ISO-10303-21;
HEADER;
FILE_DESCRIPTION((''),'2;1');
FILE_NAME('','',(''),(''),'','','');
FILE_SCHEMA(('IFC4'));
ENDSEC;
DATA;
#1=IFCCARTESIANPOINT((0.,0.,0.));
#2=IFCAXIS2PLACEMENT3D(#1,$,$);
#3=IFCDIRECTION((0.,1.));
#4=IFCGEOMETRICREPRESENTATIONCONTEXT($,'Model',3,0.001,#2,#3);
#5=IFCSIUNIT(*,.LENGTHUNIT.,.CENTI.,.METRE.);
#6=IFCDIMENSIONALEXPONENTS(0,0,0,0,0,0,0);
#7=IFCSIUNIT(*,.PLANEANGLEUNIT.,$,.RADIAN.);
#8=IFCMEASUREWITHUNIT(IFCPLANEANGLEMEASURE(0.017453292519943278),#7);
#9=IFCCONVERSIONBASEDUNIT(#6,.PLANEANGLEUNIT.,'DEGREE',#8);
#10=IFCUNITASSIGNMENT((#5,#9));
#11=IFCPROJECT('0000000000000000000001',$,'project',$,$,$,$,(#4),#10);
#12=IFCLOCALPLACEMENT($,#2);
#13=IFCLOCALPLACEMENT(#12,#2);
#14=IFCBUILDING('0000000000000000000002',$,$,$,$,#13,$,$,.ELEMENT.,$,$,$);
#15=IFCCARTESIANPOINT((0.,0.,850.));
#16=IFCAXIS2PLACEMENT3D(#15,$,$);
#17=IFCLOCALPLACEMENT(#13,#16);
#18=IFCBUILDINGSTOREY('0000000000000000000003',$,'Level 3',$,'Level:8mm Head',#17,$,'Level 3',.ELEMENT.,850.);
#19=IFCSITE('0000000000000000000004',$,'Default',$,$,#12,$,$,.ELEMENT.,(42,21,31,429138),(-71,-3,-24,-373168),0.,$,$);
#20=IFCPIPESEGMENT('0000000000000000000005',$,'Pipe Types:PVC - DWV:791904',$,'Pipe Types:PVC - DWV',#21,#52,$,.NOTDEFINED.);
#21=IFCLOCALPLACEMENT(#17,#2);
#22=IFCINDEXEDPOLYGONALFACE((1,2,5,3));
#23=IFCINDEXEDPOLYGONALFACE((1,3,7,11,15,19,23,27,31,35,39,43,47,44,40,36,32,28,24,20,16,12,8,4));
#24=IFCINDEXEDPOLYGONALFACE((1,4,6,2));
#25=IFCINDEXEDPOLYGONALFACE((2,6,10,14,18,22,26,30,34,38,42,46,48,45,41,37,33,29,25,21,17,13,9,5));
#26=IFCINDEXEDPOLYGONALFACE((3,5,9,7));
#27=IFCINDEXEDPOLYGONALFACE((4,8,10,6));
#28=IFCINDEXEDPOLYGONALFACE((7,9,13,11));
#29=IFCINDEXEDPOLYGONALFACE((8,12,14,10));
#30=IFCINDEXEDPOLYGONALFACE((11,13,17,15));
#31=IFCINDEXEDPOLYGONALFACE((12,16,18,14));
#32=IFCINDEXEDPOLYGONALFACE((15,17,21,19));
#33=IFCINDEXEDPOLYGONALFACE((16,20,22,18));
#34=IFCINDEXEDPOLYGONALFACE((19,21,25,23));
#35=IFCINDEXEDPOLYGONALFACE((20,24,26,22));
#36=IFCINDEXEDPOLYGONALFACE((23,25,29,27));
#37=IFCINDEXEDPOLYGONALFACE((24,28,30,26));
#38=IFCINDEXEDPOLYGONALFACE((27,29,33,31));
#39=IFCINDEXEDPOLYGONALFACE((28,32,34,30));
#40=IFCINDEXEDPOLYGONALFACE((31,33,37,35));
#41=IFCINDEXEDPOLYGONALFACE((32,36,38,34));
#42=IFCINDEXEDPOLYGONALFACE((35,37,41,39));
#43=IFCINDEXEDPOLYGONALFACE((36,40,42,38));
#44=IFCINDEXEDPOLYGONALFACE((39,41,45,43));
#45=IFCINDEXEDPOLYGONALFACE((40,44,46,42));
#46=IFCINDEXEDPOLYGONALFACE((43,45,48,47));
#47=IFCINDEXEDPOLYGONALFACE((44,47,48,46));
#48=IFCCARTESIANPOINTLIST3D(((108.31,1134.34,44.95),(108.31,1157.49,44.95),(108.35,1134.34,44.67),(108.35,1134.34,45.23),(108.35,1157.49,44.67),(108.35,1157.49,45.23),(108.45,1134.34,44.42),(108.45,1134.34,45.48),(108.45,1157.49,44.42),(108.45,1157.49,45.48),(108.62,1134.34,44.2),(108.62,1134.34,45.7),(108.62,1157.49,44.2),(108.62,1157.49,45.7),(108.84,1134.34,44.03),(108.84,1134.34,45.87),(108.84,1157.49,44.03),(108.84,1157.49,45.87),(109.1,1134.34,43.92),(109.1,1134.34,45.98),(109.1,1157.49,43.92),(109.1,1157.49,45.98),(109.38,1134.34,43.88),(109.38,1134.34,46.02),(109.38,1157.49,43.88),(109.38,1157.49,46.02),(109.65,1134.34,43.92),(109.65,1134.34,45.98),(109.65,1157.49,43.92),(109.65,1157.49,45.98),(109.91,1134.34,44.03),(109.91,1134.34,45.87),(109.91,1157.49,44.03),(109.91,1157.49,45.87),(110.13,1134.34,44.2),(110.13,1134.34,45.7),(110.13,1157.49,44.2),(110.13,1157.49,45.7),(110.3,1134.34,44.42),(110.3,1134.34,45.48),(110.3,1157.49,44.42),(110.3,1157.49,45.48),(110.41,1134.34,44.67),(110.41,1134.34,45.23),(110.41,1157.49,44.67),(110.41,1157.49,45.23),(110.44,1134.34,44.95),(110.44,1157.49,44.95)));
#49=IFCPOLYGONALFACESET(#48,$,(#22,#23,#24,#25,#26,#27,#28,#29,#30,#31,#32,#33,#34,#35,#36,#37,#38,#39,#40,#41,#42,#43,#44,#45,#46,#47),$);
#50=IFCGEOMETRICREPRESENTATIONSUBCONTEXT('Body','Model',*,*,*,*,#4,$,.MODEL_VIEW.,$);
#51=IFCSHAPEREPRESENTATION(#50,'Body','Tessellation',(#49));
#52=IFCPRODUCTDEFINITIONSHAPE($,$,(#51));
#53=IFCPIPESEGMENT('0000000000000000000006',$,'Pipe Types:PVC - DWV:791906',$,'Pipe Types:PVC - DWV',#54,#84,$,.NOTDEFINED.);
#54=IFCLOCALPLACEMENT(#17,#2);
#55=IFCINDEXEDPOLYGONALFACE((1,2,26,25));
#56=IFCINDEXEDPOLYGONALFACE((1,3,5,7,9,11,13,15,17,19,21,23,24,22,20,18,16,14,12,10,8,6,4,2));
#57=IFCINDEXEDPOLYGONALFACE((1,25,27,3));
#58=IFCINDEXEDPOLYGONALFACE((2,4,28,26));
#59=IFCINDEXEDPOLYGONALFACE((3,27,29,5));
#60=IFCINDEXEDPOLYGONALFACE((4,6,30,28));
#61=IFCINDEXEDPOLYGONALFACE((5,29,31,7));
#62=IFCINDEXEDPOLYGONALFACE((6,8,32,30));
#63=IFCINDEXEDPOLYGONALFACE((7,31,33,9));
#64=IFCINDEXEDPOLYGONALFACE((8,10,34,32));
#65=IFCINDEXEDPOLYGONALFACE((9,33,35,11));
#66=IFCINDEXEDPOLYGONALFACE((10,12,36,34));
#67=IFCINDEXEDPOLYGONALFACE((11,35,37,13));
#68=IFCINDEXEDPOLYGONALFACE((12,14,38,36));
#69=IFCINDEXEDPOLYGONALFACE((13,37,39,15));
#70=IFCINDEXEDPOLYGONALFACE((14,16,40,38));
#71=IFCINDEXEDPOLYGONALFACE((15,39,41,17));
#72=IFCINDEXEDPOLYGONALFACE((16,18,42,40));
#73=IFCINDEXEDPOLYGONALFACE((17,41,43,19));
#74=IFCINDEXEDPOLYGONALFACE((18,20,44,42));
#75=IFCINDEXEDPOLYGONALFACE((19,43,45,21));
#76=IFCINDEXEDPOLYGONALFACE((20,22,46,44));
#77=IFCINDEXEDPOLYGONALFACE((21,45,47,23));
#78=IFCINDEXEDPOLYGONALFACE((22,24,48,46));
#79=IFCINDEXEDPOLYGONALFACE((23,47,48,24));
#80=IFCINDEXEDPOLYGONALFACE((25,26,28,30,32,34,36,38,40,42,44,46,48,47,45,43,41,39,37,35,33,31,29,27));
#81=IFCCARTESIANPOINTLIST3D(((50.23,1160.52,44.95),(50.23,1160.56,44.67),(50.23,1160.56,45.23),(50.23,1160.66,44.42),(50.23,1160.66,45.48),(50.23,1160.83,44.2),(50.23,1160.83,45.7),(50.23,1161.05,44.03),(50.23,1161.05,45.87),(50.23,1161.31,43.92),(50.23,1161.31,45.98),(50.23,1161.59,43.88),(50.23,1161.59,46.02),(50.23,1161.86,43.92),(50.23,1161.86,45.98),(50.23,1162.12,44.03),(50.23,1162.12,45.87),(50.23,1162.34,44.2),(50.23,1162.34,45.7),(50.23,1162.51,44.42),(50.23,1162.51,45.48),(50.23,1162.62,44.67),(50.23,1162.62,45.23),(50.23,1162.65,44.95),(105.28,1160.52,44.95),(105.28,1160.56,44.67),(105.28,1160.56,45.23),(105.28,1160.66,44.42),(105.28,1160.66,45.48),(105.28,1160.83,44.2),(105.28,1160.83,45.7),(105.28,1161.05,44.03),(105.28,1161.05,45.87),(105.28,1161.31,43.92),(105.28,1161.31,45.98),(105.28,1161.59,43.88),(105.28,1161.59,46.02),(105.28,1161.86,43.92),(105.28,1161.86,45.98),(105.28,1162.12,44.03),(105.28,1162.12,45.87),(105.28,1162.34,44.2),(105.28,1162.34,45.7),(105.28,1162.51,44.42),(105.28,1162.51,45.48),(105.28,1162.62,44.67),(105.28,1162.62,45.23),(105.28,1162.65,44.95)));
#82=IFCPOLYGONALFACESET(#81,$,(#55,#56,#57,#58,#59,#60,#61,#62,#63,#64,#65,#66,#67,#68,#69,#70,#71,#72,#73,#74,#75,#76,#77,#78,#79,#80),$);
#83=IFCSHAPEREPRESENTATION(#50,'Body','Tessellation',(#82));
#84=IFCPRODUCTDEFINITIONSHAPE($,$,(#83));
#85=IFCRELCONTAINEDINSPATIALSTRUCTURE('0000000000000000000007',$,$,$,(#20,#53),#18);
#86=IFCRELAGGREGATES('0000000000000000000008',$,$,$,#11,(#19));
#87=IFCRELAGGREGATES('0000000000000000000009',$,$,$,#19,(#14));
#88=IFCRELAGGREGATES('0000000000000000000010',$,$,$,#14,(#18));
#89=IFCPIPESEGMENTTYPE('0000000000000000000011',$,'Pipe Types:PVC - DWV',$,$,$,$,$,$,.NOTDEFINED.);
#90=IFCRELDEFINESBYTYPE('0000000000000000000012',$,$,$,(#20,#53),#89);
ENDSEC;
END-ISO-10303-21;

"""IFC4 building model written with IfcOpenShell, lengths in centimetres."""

from ifc_helpers import new_model, entity, si_unit, converted_unit, direction, frame, origin, place, context, subcontext, project, spatial, arc, indexed_curve, outline, extrude, type_object, element, save


model = new_model("IFC4")

# Units and contexts
model_context = context("Model", 3, precision=0.001, world=origin(), true_north=direction((0.0, 1.0)))
body_context = subcontext(model_context, "Body", "Model", "MODEL_VIEW")
ifc_project = project(units=[si_unit("LENGTHUNIT", "METRE", prefix="CENTI"), converted_unit("PLANEANGLEUNIT", "DEGREE", entity("IfcPlaneAngleMeasure", 0.017453292519943278), si_unit("PLANEANGLEUNIT", "RADIAN"), dimensions=[0, 0, 0, 0, 0, 0, 0])], contexts=[model_context])

# Site, building, storey
site_placement = place(None, origin())
site = spatial("IfcSite", under=ifc_project, at=site_placement, Name="Default", CompositionType="ELEMENT", RefLatitude=(42, 21, 31, 429138), RefLongitude=(-71, -3, -24, -373168), RefElevation=0.0)
building_placement = place(site_placement, origin())
building = spatial("IfcBuilding", under=site, at=building_placement, CompositionType="ELEMENT")
storey_placement = place(building_placement, frame((0.0, 0.0, 850.0)))
storey = spatial("IfcBuildingStorey", under=building, at=storey_placement, Name="Level 3", ObjectType="Level:8mm Head", LongName="Level 3", CompositionType="ELEMENT", Elevation=850.0)

# Pipe segments
pipe_segment_type = type_object("IfcPipeSegmentType", Name="Pipe Types:PVC - DWV", PredefinedType="NOTDEFINED")
pipe_segment_1_placement = place(storey_placement, origin())
element("IfcPipeSegment", 1, at=pipe_segment_1_placement, inside=storey, type_object=pipe_segment_type, Name="Pipe Types:PVC - DWV:791904", ObjectType="Pipe Types:PVC - DWV", PredefinedType="NOTDEFINED", context=body_context, shape_type="SweptSolid", body=[
    extrude(outline(indexed_curve([(1.07, 0.0), (0.75, 0.75), (0.0, 1.07), (-0.75, 0.75), (-1.07, 0.0), (-0.75, -0.75), (0.0, -1.07), (0.75, -0.75)], segments=[arc(1, 2, 3), arc(3, 4, 5), arc(5, 6, 7), arc(7, 8, 1)], self_intersect=False)), frame((109.38, 1134.34, 44.95), z_axis=(0.0, 1.0, 0.0), x_axis=(1.0, 0.0, 0.0)), (0.0, 0.0, 1.0), 23.14),
])
pipe_segment_2_placement = place(storey_placement, origin())
element("IfcPipeSegment", 2, at=pipe_segment_2_placement, inside=storey, type_object=pipe_segment_type, Name="Pipe Types:PVC - DWV:791906", ObjectType="Pipe Types:PVC - DWV", PredefinedType="NOTDEFINED", context=body_context, shape_type="SweptSolid", body=[
    extrude(outline(indexed_curve([(1.07, 0.0), (0.75, 0.75), (0.0, 1.07), (-0.75, 0.75), (-1.07, 0.0), (-0.75, -0.75), (0.0, -1.07), (0.75, -0.75)], segments=[arc(1, 2, 3), arc(3, 4, 5), arc(5, 6, 7), arc(7, 8, 1)], self_intersect=False)), frame((50.23, 1161.59, 44.95), z_axis=(1.0, 0.0, 0.0), x_axis=(0.0, 1.0, 0.0)), (0.0, 0.0, 1.0), 55.04),
])

save(model, "model.ifc")
